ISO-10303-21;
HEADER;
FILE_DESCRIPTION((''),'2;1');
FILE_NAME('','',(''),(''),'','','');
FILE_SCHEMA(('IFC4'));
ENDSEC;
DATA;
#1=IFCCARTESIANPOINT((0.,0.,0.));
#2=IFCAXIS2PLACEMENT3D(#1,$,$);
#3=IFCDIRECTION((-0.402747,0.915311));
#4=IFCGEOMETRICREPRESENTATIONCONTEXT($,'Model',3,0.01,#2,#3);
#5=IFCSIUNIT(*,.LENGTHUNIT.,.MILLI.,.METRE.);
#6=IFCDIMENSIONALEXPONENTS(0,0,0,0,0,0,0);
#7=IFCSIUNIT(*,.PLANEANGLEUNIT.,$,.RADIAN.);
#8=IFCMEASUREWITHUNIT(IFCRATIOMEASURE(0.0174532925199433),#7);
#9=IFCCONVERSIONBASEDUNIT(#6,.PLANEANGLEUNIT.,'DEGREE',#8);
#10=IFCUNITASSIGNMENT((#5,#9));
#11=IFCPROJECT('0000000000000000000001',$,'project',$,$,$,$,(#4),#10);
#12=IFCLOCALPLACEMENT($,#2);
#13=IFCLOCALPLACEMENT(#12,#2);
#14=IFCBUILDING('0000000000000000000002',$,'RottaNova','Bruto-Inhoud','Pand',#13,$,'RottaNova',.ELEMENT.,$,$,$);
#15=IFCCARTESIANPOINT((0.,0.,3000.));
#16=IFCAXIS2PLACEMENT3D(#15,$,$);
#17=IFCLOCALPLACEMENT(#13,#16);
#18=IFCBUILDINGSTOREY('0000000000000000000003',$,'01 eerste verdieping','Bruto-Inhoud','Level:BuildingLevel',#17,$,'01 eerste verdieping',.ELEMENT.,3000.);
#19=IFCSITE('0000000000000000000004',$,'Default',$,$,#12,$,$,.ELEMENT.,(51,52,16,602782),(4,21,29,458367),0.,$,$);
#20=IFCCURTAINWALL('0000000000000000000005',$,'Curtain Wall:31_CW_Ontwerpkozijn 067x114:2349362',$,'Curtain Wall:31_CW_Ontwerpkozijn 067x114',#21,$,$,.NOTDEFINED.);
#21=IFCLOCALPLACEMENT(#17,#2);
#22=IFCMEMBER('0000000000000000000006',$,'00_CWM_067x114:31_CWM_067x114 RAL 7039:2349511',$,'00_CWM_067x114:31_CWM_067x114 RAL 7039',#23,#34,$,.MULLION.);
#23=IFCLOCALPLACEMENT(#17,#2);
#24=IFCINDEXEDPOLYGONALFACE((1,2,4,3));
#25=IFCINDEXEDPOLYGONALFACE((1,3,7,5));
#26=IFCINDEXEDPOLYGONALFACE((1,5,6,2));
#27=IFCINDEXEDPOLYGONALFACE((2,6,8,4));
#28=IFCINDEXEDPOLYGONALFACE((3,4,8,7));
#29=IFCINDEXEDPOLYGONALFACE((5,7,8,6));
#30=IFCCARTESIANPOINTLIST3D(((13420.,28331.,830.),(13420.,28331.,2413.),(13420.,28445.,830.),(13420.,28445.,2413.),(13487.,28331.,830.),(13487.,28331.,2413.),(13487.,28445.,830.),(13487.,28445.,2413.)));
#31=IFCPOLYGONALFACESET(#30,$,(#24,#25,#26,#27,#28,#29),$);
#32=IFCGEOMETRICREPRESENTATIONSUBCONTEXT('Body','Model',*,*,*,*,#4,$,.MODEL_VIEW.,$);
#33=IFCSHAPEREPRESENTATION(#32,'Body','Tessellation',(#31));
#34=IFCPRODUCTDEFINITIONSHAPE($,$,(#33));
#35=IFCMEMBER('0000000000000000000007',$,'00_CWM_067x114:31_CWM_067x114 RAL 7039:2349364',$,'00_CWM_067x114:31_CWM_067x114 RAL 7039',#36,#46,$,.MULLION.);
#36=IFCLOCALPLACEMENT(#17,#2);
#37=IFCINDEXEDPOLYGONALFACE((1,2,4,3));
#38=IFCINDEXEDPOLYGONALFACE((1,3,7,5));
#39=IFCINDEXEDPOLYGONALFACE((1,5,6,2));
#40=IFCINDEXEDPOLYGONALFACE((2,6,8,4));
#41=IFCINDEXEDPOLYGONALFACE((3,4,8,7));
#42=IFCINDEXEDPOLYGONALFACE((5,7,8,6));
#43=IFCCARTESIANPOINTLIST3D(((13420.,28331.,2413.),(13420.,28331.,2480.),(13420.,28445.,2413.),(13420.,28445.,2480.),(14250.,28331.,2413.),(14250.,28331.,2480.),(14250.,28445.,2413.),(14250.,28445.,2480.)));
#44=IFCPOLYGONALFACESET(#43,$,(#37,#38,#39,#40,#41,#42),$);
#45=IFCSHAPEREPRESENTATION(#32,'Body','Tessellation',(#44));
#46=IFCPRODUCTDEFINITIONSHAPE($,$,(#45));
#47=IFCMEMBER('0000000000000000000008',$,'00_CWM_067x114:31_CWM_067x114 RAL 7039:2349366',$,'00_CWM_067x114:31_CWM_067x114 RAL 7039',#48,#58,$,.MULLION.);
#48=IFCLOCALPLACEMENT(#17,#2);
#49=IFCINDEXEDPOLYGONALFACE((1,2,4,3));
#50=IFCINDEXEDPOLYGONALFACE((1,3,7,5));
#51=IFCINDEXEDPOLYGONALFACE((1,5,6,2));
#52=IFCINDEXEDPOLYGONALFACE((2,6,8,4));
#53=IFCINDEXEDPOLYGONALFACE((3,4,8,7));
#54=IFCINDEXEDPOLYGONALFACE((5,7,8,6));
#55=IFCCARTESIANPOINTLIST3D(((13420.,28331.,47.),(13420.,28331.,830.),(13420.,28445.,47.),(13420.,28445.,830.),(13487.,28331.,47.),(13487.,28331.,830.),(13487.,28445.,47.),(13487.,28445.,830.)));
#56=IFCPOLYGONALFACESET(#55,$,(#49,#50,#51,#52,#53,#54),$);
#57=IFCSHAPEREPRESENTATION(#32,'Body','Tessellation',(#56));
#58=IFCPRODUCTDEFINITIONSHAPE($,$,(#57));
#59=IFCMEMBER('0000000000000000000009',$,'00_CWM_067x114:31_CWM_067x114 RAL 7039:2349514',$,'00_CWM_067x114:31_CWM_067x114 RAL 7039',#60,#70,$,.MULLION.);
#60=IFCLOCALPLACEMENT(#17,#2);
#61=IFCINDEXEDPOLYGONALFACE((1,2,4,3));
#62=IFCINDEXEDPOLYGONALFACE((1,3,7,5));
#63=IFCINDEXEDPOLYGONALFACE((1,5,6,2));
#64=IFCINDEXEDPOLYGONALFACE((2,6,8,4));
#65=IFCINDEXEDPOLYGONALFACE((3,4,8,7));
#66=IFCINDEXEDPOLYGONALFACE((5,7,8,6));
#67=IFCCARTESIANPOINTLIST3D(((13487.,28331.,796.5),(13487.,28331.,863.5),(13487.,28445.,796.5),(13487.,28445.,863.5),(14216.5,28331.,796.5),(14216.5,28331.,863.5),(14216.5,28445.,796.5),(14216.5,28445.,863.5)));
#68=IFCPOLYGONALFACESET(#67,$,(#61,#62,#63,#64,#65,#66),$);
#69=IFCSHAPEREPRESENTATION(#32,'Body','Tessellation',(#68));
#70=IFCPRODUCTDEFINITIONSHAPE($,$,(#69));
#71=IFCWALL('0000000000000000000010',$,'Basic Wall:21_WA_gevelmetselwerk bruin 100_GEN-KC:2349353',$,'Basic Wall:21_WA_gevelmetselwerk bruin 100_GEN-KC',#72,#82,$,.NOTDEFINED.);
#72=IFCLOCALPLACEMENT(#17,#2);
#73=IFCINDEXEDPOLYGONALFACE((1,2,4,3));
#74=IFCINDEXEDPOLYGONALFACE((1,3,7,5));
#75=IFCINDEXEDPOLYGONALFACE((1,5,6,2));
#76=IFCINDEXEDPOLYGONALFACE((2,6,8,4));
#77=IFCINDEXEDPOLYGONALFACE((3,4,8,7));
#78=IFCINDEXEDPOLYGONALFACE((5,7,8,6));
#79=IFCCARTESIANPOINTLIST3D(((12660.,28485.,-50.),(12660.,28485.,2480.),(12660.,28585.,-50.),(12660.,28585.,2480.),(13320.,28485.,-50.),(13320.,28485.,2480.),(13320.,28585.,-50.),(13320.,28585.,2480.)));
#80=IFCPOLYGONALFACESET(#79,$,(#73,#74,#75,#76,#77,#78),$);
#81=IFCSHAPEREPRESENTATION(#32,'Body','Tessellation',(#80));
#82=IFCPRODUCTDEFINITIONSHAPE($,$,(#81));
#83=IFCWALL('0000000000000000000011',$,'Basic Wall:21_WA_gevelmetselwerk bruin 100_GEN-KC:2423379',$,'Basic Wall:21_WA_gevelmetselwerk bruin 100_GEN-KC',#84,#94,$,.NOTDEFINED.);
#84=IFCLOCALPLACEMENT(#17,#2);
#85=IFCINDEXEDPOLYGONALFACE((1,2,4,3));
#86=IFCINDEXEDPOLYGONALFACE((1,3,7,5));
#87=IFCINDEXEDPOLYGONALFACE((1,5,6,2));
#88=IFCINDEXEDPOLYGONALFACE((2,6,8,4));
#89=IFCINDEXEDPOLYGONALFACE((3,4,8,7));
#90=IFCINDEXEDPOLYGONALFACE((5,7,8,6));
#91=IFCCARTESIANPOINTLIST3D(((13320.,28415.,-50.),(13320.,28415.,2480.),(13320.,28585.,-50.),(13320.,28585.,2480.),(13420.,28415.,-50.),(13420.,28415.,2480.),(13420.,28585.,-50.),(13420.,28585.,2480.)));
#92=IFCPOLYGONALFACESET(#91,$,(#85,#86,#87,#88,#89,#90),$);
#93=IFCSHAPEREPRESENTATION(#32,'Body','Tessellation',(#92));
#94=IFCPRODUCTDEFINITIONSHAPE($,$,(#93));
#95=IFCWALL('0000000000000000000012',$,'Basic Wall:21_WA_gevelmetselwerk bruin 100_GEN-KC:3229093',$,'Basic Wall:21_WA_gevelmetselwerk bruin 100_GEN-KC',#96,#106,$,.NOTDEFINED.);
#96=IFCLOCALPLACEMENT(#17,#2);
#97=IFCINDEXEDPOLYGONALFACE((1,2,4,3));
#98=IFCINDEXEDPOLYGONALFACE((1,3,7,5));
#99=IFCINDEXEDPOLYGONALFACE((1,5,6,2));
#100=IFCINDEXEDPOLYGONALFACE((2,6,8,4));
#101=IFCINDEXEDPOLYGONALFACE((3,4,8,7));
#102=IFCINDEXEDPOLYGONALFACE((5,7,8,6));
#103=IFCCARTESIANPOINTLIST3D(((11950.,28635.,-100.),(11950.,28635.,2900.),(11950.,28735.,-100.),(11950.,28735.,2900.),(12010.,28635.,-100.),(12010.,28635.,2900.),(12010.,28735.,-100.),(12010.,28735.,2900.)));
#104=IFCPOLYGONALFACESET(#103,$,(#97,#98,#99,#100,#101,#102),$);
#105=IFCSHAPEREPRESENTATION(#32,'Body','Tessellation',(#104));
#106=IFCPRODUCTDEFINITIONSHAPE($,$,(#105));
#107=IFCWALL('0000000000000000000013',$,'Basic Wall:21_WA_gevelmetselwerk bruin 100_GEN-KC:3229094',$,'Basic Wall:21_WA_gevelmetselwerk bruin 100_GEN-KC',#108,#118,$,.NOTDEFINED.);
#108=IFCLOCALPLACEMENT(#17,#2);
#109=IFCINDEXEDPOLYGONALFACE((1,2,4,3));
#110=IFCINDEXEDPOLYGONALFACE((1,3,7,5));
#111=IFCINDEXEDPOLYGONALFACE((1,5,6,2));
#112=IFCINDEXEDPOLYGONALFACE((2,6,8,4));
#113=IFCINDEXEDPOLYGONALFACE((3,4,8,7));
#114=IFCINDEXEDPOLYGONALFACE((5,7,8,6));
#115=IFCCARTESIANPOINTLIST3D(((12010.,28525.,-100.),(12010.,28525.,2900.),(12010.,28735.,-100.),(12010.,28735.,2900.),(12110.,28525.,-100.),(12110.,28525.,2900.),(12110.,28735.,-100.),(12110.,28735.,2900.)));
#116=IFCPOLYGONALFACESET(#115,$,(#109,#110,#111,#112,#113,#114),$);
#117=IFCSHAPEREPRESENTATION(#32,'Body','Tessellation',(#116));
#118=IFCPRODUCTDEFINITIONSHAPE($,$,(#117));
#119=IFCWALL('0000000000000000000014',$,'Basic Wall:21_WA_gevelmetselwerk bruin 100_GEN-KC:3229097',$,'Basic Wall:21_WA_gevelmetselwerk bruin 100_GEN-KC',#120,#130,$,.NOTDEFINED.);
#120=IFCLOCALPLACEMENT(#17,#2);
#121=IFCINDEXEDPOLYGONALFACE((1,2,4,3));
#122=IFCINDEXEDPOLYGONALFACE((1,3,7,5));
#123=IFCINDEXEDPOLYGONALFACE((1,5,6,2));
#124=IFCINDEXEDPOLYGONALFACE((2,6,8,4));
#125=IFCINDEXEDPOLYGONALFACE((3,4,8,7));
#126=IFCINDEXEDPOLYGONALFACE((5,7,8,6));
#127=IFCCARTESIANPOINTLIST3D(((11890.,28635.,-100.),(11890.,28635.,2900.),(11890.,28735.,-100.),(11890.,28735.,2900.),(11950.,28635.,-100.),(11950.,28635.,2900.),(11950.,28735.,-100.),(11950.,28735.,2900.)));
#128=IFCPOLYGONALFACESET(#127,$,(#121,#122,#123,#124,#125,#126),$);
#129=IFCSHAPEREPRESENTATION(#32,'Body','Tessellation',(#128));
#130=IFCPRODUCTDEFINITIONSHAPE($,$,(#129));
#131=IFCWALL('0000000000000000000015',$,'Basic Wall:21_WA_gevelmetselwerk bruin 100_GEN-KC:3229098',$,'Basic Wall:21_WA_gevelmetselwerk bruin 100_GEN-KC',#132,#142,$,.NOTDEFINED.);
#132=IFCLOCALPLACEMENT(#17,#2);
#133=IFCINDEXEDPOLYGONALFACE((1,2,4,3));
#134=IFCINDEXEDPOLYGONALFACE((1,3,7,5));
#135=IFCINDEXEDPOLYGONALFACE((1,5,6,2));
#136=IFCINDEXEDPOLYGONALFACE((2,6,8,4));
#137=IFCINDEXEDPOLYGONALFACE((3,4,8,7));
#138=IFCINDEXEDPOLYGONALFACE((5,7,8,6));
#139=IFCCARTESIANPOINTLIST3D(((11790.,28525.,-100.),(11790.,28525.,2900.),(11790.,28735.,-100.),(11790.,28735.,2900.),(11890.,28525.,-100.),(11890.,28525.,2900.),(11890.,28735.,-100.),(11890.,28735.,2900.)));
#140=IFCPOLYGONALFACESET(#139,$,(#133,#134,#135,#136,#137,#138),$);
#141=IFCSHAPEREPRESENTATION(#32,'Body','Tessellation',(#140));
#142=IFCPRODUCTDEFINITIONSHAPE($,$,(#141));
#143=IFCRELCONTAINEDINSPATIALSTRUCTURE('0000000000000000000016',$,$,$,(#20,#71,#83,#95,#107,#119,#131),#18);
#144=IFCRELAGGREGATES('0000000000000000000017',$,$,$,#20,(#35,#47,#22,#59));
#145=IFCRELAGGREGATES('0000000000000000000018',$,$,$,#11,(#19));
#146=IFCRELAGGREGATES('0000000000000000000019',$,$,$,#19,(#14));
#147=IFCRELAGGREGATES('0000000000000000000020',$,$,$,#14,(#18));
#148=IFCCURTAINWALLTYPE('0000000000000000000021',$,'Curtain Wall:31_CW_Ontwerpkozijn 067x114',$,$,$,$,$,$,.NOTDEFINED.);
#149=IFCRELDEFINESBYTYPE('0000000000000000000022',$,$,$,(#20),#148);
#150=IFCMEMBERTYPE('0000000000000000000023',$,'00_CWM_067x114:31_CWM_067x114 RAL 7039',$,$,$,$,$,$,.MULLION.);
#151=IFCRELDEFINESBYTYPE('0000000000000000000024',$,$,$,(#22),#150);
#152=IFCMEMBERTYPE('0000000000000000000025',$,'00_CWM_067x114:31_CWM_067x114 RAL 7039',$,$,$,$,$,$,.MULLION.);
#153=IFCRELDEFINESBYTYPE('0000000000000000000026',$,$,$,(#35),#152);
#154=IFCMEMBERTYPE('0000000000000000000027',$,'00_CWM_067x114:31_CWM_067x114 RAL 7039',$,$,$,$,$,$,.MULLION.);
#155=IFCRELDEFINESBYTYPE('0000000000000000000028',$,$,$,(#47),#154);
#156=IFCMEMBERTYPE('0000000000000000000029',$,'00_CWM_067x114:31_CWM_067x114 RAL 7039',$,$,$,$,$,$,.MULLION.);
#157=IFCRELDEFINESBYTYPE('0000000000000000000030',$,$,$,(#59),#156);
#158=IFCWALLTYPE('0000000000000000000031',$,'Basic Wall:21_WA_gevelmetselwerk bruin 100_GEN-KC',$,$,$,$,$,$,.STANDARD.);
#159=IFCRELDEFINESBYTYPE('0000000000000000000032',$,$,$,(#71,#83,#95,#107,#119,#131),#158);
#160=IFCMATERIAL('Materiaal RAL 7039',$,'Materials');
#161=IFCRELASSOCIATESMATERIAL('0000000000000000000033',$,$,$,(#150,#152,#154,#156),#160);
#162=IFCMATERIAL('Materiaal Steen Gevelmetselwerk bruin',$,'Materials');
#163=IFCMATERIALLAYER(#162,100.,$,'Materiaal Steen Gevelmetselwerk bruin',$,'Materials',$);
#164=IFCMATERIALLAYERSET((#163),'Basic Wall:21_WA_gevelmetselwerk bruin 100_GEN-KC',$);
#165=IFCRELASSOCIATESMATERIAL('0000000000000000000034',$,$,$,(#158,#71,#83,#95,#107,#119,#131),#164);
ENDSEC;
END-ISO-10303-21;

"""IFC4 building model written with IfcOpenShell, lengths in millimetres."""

from ifc_helpers import new_model, entity, si_unit, converted_unit, direction, frame, frame_2d, origin, origin_2d_with_axis, place, context, subcontext, project, spatial, rectangle, extrude, source, transform, mapped, material, layer, layer_set, material_profile, profile_set, type_object, type_shapes, element, aggregate, save


model = new_model("IFC4")

# Units and contexts
model_context = context("Model", 3, precision=0.01, world=origin(), true_north=direction((-0.402747, 0.915311)))
body_context = subcontext(model_context, "Body", "Model", "MODEL_VIEW")
ifc_project = project(units=[si_unit("LENGTHUNIT", "METRE", prefix="MILLI"), converted_unit("PLANEANGLEUNIT", "DEGREE", entity("IfcRatioMeasure", 0.0174532925199433), si_unit("PLANEANGLEUNIT", "RADIAN"), dimensions=[0, 0, 0, 0, 0, 0, 0])], contexts=[model_context])

# Site, building, storey
site_placement = place(None, origin())
site = spatial("IfcSite", under=ifc_project, at=site_placement, Name="Default", CompositionType="ELEMENT", RefLatitude=(51, 52, 16, 602782), RefLongitude=(4, 21, 29, 458367), RefElevation=0.0)
building_placement = place(site_placement, origin())
building = spatial("IfcBuilding", under=site, at=building_placement, Name="RottaNova", Description="Bruto-Inhoud", ObjectType="Pand", LongName="RottaNova", CompositionType="ELEMENT")
storey_placement = place(building_placement, frame((0.0, 0.0, 3000.0)))
storey = spatial("IfcBuildingStorey", under=building, at=storey_placement, Name="01 eerste verdieping", Description="Bruto-Inhoud", ObjectType="Level:BuildingLevel", LongName="01 eerste verdieping", CompositionType="ELEMENT", Elevation=3000.0)

# Curtain wall, members
curtain_wall_type = type_object("IfcCurtainWallType", Name="Curtain Wall:31_CW_Ontwerpkozijn 067x114", PredefinedType="NOTDEFINED")
curtain_wall_placement = place(storey_placement, frame((0.0, 0.0, -3000.0)))
curtain_wall = element("IfcCurtainWall", 1, at=curtain_wall_placement, inside=storey, type_object=curtain_wall_type, Name="Curtain Wall:31_CW_Ontwerpkozijn 067x114:2349362", ObjectType="Curtain Wall:31_CW_Ontwerpkozijn 067x114", PredefinedType="NOTDEFINED")
ifc_material_1 = material(Name="Materiaal RAL 7039", Category="Materials")
ifc_material_profile = material_profile(ifc_material_1, rectangle(XDim=114.0, YDim=67.0, at=origin_2d_with_axis()), Name="31_CWM_067x114 RAL 7039")
ifc_profile_set = profile_set([ifc_material_profile], Name="31_CWM_067x114 RAL 7039")
member_type_1 = type_object("IfcMemberType", Name="00_CWM_067x114:31_CWM_067x114 RAL 7039", PredefinedType="MULLION", material=ifc_profile_set)
shared_shape_1 = source(origin(), body_context, "Body", "SweptSolid", [
    extrude(rectangle(XDim=114.0, YDim=67.0, at=origin_2d_with_axis()), frame((-33.5, 57.0, -1583.0), z_axis=(0.0, 0.0, 1.0), x_axis=(0.0, -1.0, 0.0)), (0.0, 0.0, 1.0), 1583.0),
])
type_shapes(member_type_1, [shared_shape_1])
member_1_placement = place(curtain_wall_placement, frame((13420.0, 28331.0, 3830.0), z_axis=(0.0, 0.0, -1.0), x_axis=(-1.0, 0.0, 0.0)))
member_1 = element("IfcMember", 2, at=member_1_placement, type_object=member_type_1, Name="00_CWM_067x114:31_CWM_067x114 RAL 7039:2349511", ObjectType="00_CWM_067x114:31_CWM_067x114 RAL 7039", PredefinedType="MULLION", context=body_context, shape_type="MappedRepresentation", body=[
    mapped(shared_shape_1, transform((0.0, 0.0, 0.0), scale=1.0)),
])
member_type_2 = type_object("IfcMemberType", Name="00_CWM_067x114:31_CWM_067x114 RAL 7039", PredefinedType="MULLION", material=ifc_profile_set)
shared_shape_2 = source(origin(), body_context, "Body", "SweptSolid", [
    extrude(rectangle(XDim=114.0, YDim=67.0, at=origin_2d_with_axis()), frame((-33.5, 57.0, -830.0), z_axis=(0.0, 0.0, 1.0), x_axis=(0.0, -1.0, 0.0)), (0.0, 0.0, 1.0), 830.0),
])
type_shapes(member_type_2, [shared_shape_2])
member_2_placement = place(curtain_wall_placement, frame((13420.0, 28331.0, 5480.0), z_axis=(-1.0, 0.0, 0.0), x_axis=(0.0, 0.0, 1.0)))
member_2 = element("IfcMember", 3, at=member_2_placement, type_object=member_type_2, Name="00_CWM_067x114:31_CWM_067x114 RAL 7039:2349364", ObjectType="00_CWM_067x114:31_CWM_067x114 RAL 7039", PredefinedType="MULLION", context=body_context, shape_type="MappedRepresentation", body=[
    mapped(shared_shape_2, transform((0.0, 0.0, 0.0), scale=1.0)),
])
member_type_3 = type_object("IfcMemberType", Name="00_CWM_067x114:31_CWM_067x114 RAL 7039", PredefinedType="MULLION", material=ifc_profile_set)
shared_shape_3 = source(origin(), body_context, "Body", "SweptSolid", [
    extrude(rectangle(XDim=114.0, YDim=67.0, at=origin_2d_with_axis()), frame((-33.5, 57.0, -783.0), z_axis=(0.0, 0.0, 1.0), x_axis=(0.0, -1.0, 0.0)), (0.0, 0.0, 1.0), 783.0),
])
type_shapes(member_type_3, [shared_shape_3])
member_3_placement = place(curtain_wall_placement, frame((13420.0, 28331.0, 3047.0), z_axis=(0.0, 0.0, -1.0), x_axis=(-1.0, 0.0, 0.0)))
member_3 = element("IfcMember", 4, at=member_3_placement, type_object=member_type_3, Name="00_CWM_067x114:31_CWM_067x114 RAL 7039:2349366", ObjectType="00_CWM_067x114:31_CWM_067x114 RAL 7039", PredefinedType="MULLION", context=body_context, shape_type="MappedRepresentation", body=[
    mapped(shared_shape_3, transform((0.0, 0.0, 0.0), scale=1.0)),
])
member_type_4 = type_object("IfcMemberType", Name="00_CWM_067x114:31_CWM_067x114 RAL 7039", PredefinedType="MULLION", material=ifc_profile_set)
shared_shape_4 = source(origin(), body_context, "Body", "SweptSolid", [
    extrude(rectangle(XDim=114.0, YDim=67.0, at=origin_2d_with_axis()), frame((0.0, 57.0, -729.5), z_axis=(0.0, 0.0, 1.0), x_axis=(0.0, -1.0, 0.0)), (0.0, 0.0, 1.0), 729.5),
])
type_shapes(member_type_4, [shared_shape_4])
member_4_placement = place(curtain_wall_placement, frame((13487.0, 28331.0, 3830.0), z_axis=(-1.0, 0.0, 0.0), x_axis=(0.0, 0.0, 1.0)))
member_4 = element("IfcMember", 5, at=member_4_placement, type_object=member_type_4, Name="00_CWM_067x114:31_CWM_067x114 RAL 7039:2349514", ObjectType="00_CWM_067x114:31_CWM_067x114 RAL 7039", PredefinedType="MULLION", context=body_context, shape_type="MappedRepresentation", body=[
    mapped(shared_shape_4, transform((0.0, 0.0, 0.0), scale=1.0)),
])
aggregate(curtain_wall, [member_2, member_3, member_1, member_4])

# Walls
ifc_material_2 = material(Name="Materiaal Steen Gevelmetselwerk bruin", Category="Materials")
ifc_layer_1 = layer(ifc_material_2, 100.0, Name="Materiaal Steen Gevelmetselwerk bruin", Category="Materials")
ifc_layer_set_1 = layer_set([ifc_layer_1], Name="Basic Wall:21_WA_gevelmetselwerk bruin 100_GEN-KC")
wall_type_1 = type_object("IfcWallType", Name="Basic Wall:21_WA_gevelmetselwerk bruin 100_GEN-KC", PredefinedType="STANDARD", material=ifc_layer_set_1)
wall_1_placement = place(storey_placement, frame((12660.0, 28535.0, -50.0)))
element("IfcWall", 6, at=wall_1_placement, inside=storey, type_object=wall_type_1, material=ifc_layer_set_1, Name="Basic Wall:21_WA_gevelmetselwerk bruin 100_GEN-KC:2349353", ObjectType="Basic Wall:21_WA_gevelmetselwerk bruin 100_GEN-KC", PredefinedType="NOTDEFINED", context=body_context, shape_type="SweptSolid", body=[
    extrude(rectangle(XDim=660.0, YDim=100.0, at=frame_2d((330.0, 0.0), x_axis=(-1.0, 0.0))), origin(), (0.0, 0.0, 1.0), 2530.0),
])
wall_2_placement = place(storey_placement, frame((13370.0, 28415.0, -50.0), z_axis=(0.0, 0.0, 1.0), x_axis=(0.0, 1.0, 0.0)))
element("IfcWall", 7, at=wall_2_placement, inside=storey, type_object=wall_type_1, material=ifc_layer_set_1, Name="Basic Wall:21_WA_gevelmetselwerk bruin 100_GEN-KC:2423379", ObjectType="Basic Wall:21_WA_gevelmetselwerk bruin 100_GEN-KC", PredefinedType="NOTDEFINED", context=body_context, shape_type="SweptSolid", body=[
    extrude(rectangle(XDim=170.0, YDim=100.0, at=frame_2d((85.0, 0.0), x_axis=(-1.0, 0.0))), origin(), (0.0, 0.0, 1.0), 2530.0),
])
wall_3_placement = place(storey_placement, frame((12010.0, 28685.0, -100.0), z_axis=(0.0, 0.0, 1.0), x_axis=(-1.0, 0.0, 0.0)))
element("IfcWall", 8, at=wall_3_placement, inside=storey, type_object=wall_type_1, material=ifc_layer_set_1, Name="Basic Wall:21_WA_gevelmetselwerk bruin 100_GEN-KC:3229093", ObjectType="Basic Wall:21_WA_gevelmetselwerk bruin 100_GEN-KC", PredefinedType="NOTDEFINED", context=body_context, shape_type="SweptSolid", body=[
    extrude(rectangle(XDim=60.0, YDim=100.0, at=frame_2d((30.0, 0.0), x_axis=(-1.0, 0.0))), origin(), (0.0, 0.0, 1.0), 3000.0),
])
wall_4_placement = place(storey_placement, frame((12060.0, 28735.0, -100.0), z_axis=(0.0, 0.0, 1.0), x_axis=(0.0, -1.0, 0.0)))
element("IfcWall", 9, at=wall_4_placement, inside=storey, type_object=wall_type_1, material=ifc_layer_set_1, Name="Basic Wall:21_WA_gevelmetselwerk bruin 100_GEN-KC:3229094", ObjectType="Basic Wall:21_WA_gevelmetselwerk bruin 100_GEN-KC", PredefinedType="NOTDEFINED", context=body_context, shape_type="SweptSolid", body=[
    extrude(rectangle(XDim=210.0, YDim=100.0, at=frame_2d((105.0, 0.0), x_axis=(-1.0, 0.0))), origin(), (0.0, 0.0, 1.0), 3000.0),
])
wall_5_placement = place(storey_placement, frame((11890.0, 28685.0, -100.0)))
element("IfcWall", 10, at=wall_5_placement, inside=storey, type_object=wall_type_1, material=ifc_layer_set_1, Name="Basic Wall:21_WA_gevelmetselwerk bruin 100_GEN-KC:3229097", ObjectType="Basic Wall:21_WA_gevelmetselwerk bruin 100_GEN-KC", PredefinedType="NOTDEFINED", context=body_context, shape_type="SweptSolid", body=[
    extrude(rectangle(XDim=60.0, YDim=100.0, at=frame_2d((30.0, 0.0), x_axis=(-1.0, 0.0))), origin(), (0.0, 0.0, 1.0), 3000.0),
])
wall_6_placement = place(storey_placement, frame((11840.0, 28735.0, -100.0), z_axis=(0.0, 0.0, 1.0), x_axis=(0.0, -1.0, 0.0)))
element("IfcWall", 11, at=wall_6_placement, inside=storey, type_object=wall_type_1, material=ifc_layer_set_1, Name="Basic Wall:21_WA_gevelmetselwerk bruin 100_GEN-KC:3229098", ObjectType="Basic Wall:21_WA_gevelmetselwerk bruin 100_GEN-KC", PredefinedType="NOTDEFINED", context=body_context, shape_type="SweptSolid", body=[
    extrude(rectangle(XDim=210.0, YDim=100.0, at=frame_2d((105.0, 0.0), x_axis=(-1.0, 0.0))), origin(), (0.0, 0.0, 1.0), 3000.0),
])

save(model, "model.ifc")
